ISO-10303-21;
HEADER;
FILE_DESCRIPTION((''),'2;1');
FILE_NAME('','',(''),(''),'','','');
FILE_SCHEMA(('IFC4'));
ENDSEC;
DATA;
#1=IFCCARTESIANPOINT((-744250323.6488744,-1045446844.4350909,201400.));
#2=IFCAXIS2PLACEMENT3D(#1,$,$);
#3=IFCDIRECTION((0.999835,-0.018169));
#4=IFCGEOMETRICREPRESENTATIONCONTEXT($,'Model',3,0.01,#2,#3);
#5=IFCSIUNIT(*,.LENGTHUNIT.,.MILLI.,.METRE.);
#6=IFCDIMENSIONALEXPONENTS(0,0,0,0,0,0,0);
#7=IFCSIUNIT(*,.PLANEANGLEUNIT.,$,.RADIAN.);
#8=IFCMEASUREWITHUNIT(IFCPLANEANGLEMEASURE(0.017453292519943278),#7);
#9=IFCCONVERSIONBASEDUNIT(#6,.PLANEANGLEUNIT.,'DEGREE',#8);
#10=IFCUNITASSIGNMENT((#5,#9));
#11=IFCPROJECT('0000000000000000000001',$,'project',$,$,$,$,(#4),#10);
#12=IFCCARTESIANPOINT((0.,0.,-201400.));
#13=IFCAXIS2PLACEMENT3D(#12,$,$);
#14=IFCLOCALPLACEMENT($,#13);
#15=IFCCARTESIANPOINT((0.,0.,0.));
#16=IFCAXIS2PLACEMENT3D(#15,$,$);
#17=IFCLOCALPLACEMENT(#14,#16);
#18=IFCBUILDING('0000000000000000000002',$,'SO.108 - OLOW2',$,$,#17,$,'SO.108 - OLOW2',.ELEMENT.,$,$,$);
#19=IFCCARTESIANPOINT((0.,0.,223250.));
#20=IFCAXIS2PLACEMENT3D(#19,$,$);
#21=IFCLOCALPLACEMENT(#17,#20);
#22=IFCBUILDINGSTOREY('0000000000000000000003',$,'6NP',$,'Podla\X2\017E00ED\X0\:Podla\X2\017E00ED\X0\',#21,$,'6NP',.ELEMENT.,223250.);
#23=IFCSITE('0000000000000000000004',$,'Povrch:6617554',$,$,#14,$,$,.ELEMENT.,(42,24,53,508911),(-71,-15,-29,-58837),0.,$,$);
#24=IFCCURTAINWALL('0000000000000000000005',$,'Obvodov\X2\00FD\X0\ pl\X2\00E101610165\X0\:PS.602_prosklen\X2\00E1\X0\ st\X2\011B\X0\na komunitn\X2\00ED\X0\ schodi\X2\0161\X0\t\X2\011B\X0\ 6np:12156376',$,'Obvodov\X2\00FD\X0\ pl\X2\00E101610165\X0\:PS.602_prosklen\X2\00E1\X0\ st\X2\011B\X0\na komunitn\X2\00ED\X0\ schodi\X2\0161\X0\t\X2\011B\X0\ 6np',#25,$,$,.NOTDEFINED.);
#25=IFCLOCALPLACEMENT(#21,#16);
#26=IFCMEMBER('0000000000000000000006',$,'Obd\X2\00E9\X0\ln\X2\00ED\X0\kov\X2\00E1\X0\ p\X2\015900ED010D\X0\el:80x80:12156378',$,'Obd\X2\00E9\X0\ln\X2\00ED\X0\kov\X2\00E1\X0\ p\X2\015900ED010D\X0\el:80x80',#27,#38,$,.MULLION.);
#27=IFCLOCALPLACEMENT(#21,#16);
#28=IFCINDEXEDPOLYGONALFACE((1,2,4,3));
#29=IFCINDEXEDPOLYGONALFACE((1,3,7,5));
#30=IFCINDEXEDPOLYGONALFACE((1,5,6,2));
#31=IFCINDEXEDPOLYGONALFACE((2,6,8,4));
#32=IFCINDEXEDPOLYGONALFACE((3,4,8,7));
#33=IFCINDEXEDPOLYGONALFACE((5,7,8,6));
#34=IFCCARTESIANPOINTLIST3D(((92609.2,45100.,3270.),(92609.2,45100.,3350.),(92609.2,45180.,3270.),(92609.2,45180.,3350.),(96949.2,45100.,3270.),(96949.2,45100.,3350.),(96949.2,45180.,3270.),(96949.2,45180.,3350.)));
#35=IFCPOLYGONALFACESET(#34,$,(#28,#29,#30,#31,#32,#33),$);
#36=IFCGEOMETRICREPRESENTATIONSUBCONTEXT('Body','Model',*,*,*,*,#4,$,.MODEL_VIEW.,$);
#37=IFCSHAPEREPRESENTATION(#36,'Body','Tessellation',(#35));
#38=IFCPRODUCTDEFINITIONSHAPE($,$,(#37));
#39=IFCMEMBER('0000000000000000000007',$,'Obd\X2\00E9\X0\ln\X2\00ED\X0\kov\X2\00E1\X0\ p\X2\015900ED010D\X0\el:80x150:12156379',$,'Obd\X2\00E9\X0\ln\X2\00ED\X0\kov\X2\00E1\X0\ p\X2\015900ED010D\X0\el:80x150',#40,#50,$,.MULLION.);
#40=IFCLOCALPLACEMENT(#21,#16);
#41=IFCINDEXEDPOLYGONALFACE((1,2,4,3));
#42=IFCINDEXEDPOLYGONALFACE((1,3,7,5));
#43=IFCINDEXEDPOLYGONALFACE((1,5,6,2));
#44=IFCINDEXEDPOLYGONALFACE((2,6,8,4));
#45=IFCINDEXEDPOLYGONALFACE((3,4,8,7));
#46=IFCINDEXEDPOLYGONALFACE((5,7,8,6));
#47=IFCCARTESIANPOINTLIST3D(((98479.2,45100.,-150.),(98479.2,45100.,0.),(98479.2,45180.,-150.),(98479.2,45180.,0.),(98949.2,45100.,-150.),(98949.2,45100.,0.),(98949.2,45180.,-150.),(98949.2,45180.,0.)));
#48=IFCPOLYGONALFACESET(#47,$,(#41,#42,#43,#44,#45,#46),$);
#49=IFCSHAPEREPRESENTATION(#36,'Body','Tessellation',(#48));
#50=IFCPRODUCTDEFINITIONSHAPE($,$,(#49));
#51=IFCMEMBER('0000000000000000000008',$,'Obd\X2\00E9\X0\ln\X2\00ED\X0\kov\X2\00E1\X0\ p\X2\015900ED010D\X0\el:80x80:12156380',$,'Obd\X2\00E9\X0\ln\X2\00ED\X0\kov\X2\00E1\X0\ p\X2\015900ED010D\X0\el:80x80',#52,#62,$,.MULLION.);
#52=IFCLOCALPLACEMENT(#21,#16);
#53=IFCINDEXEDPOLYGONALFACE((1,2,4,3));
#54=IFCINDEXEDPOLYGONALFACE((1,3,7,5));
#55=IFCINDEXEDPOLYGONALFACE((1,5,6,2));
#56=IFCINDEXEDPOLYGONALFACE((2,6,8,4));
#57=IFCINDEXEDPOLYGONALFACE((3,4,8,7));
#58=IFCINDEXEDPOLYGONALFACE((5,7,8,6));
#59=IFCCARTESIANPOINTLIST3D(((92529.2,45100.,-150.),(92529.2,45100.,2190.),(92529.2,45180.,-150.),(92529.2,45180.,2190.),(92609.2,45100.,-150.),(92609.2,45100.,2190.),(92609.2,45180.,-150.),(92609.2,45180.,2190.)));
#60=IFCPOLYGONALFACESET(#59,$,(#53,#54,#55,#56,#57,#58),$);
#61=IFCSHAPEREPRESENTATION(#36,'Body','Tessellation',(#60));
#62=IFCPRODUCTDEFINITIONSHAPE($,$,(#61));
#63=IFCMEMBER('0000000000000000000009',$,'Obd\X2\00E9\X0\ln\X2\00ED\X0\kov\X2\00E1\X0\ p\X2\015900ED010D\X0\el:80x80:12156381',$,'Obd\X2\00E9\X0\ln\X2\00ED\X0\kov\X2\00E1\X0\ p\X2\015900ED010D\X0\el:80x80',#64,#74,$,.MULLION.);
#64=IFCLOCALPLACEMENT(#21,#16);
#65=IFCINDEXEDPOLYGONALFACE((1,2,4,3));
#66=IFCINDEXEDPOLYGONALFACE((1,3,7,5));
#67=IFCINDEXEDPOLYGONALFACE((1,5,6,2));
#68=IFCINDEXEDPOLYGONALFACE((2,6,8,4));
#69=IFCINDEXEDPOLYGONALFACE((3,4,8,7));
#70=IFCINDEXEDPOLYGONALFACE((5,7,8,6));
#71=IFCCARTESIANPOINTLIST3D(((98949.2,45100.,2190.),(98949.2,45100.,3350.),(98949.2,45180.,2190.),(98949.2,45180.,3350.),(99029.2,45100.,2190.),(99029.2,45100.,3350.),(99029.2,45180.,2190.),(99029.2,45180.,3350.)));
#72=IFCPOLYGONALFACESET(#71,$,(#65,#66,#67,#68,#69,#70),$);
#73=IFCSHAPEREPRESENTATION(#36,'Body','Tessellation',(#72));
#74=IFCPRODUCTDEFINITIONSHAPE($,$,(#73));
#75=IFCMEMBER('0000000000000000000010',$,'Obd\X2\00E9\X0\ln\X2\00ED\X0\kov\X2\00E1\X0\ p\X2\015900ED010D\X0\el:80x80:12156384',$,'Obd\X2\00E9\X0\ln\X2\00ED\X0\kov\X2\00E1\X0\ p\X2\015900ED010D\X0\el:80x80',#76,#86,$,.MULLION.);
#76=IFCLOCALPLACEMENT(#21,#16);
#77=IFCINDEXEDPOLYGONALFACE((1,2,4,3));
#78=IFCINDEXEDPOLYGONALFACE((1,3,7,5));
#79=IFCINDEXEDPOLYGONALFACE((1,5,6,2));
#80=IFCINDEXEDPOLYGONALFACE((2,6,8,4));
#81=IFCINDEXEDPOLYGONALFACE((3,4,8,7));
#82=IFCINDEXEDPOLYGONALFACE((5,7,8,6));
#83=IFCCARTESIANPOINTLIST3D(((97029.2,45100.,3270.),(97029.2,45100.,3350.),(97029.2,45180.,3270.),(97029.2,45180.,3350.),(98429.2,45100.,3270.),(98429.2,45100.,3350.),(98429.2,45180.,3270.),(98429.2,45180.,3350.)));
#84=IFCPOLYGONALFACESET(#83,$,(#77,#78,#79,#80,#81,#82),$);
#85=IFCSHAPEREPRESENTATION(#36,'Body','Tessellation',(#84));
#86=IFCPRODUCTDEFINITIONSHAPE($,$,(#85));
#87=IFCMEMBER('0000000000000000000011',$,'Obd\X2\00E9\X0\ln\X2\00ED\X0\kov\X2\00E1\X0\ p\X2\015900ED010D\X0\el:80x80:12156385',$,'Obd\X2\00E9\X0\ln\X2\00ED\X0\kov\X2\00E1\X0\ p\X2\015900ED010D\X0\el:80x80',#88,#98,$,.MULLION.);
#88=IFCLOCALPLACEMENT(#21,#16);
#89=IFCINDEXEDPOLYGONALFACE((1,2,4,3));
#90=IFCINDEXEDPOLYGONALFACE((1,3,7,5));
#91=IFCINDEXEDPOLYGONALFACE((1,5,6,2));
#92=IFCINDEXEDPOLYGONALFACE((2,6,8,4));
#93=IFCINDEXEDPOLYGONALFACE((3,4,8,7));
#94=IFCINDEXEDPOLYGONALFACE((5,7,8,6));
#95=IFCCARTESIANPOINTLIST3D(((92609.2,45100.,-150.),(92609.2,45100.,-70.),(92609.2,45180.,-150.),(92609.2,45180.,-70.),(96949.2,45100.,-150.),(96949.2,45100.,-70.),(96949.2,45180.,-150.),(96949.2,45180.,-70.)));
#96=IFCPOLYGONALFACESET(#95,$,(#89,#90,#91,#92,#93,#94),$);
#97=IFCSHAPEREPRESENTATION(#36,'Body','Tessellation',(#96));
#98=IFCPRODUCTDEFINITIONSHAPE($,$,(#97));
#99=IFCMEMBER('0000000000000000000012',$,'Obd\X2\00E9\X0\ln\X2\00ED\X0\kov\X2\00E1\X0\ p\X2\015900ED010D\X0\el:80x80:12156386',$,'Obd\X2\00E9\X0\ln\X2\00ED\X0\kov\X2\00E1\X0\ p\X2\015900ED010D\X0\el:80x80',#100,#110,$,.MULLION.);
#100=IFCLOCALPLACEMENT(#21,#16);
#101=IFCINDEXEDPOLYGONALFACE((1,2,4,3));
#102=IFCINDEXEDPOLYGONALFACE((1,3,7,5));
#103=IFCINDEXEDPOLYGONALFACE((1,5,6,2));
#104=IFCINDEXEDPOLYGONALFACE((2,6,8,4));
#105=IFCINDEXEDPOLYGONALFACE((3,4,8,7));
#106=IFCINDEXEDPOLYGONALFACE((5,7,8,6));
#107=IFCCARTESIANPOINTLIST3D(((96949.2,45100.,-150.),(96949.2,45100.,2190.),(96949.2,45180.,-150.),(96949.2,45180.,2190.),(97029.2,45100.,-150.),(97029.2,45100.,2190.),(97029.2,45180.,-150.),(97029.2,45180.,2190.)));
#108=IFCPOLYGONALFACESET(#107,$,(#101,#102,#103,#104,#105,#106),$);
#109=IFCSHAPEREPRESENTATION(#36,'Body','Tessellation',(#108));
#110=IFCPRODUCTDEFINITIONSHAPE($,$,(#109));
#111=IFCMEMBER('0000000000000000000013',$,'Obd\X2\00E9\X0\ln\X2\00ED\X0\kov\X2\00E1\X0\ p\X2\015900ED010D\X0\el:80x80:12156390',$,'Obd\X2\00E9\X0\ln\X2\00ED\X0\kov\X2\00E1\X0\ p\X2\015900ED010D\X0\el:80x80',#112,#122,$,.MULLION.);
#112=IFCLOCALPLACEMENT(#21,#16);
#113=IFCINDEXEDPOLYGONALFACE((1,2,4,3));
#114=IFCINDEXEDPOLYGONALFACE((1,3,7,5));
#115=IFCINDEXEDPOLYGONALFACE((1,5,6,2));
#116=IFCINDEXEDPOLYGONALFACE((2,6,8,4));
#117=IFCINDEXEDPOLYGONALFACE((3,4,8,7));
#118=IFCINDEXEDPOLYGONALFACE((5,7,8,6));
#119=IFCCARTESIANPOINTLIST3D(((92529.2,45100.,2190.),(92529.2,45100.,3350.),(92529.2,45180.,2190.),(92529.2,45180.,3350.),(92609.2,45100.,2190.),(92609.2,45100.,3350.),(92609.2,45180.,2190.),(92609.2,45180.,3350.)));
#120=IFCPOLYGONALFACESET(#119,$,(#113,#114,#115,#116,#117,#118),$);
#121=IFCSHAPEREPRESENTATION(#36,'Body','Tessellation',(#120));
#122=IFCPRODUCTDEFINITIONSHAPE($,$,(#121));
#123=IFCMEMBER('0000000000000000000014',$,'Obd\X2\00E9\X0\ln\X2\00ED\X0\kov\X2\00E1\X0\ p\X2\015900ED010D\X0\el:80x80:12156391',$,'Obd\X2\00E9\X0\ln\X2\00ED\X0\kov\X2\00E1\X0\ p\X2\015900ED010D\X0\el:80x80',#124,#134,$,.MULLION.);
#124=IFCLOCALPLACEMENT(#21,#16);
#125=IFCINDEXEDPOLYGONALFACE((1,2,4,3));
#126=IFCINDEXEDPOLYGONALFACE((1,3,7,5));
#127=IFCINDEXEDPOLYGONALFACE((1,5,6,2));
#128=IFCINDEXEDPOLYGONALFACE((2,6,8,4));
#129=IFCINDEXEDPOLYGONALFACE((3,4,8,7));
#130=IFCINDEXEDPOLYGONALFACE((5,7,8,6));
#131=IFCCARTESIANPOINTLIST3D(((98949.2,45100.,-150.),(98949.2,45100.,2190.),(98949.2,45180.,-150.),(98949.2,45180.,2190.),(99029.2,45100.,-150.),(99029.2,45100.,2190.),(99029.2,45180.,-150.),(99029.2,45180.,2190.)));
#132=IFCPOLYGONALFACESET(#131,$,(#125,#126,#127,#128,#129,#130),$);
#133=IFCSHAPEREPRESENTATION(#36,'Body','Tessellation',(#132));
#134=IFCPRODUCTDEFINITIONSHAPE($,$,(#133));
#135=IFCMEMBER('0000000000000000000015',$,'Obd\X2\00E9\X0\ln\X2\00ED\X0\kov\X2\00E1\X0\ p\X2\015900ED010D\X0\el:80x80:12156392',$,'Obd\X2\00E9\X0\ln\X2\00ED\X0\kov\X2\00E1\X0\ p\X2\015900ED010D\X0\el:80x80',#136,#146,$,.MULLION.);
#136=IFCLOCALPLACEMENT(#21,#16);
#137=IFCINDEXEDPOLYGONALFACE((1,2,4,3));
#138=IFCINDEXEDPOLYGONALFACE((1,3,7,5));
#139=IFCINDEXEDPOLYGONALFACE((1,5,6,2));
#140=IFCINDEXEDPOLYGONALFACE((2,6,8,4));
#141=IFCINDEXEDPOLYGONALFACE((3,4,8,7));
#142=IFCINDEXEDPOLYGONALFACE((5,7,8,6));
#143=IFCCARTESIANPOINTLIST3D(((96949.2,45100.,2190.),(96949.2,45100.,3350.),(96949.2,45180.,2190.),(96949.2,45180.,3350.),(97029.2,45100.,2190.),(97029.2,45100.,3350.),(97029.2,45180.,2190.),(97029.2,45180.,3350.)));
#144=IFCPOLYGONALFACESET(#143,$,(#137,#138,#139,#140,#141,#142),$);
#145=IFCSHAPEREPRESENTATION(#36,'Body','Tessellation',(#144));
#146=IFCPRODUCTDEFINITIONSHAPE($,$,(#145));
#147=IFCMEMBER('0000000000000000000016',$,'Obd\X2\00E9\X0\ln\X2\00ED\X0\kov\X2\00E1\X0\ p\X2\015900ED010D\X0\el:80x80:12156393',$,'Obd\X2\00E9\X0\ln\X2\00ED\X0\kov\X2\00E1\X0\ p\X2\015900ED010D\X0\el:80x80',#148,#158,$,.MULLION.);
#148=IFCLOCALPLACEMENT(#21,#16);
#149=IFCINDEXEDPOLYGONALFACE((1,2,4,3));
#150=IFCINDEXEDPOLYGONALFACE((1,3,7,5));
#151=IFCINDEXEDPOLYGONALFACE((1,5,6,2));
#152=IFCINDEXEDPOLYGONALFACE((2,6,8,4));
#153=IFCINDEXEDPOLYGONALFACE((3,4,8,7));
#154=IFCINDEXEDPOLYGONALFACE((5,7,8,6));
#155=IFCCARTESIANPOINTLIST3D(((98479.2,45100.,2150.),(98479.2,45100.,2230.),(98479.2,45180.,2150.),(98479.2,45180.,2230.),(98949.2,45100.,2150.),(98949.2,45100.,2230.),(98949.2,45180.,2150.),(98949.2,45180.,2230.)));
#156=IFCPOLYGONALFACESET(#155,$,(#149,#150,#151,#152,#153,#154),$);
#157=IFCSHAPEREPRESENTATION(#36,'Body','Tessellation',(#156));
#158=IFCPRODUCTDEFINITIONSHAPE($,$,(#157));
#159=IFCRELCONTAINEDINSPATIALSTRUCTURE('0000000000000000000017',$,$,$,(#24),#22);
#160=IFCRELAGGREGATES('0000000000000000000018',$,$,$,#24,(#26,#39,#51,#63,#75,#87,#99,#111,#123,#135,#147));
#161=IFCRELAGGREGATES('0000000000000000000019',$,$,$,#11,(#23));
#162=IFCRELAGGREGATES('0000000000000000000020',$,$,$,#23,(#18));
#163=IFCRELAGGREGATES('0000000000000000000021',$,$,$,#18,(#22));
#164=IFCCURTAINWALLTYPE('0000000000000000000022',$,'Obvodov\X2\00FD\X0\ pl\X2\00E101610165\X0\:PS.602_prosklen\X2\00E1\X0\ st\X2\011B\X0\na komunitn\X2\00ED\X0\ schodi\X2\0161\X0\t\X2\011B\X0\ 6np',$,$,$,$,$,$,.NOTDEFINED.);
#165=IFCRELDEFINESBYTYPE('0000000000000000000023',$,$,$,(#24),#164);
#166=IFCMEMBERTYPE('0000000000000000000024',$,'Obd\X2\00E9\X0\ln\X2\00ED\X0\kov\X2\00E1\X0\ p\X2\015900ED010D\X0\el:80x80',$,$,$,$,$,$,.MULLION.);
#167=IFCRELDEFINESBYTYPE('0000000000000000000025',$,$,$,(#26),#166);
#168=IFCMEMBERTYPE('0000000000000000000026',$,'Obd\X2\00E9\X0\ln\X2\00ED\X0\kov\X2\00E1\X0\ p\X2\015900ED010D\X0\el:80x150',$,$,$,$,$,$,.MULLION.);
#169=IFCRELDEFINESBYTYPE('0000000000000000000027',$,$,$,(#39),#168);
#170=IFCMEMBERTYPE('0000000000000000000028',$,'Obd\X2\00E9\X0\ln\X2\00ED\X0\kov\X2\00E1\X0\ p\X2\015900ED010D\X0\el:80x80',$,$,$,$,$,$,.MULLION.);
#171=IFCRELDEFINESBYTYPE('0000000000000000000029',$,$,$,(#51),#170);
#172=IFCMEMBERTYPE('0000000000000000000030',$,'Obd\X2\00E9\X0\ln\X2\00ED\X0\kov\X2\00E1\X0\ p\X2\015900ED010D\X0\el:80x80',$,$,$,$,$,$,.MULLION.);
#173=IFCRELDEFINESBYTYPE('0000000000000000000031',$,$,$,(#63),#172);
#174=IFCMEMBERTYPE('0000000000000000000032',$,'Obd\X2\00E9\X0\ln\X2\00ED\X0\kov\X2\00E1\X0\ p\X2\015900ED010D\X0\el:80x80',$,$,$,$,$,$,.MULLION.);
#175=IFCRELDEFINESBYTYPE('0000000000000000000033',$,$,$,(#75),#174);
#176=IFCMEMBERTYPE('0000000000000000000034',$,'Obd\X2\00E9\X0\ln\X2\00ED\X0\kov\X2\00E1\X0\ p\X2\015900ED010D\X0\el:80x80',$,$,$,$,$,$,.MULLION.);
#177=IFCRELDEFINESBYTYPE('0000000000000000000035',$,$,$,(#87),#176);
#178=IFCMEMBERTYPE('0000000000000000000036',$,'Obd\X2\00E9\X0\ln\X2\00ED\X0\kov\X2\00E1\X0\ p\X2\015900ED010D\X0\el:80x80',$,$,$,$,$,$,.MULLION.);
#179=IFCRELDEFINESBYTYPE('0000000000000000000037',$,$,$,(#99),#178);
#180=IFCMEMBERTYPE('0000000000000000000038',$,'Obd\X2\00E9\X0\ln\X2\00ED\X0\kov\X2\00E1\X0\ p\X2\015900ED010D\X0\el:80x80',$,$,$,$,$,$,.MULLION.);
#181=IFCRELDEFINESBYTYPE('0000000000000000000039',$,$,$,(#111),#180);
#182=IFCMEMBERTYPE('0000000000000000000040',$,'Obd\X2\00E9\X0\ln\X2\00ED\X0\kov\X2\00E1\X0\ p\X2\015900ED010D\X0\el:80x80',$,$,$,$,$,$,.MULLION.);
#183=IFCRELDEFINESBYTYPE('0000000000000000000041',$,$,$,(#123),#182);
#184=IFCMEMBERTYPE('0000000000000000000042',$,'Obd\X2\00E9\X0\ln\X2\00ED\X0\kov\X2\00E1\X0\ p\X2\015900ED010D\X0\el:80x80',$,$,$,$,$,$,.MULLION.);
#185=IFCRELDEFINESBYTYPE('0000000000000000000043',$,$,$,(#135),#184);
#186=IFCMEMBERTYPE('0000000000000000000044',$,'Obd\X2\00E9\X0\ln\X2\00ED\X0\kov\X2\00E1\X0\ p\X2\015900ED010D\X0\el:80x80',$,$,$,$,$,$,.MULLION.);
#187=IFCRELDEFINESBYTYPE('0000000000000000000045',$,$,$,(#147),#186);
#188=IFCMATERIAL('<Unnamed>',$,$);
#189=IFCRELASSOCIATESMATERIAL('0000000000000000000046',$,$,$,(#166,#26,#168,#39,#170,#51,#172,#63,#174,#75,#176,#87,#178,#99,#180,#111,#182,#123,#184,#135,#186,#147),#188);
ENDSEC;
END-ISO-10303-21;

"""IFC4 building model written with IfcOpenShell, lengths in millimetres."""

from ifc_helpers import new_model, entity, si_unit, converted_unit, direction, frame, origin, place, context, subcontext, project, spatial, indexed_curve, outline, extrude, source, transform, mapped, material, type_object, type_shapes, element, aggregate, save


model = new_model("IFC4")

# Units and contexts
model_context = context("Model", 3, precision=0.01, world=frame((-744250323.6488744, -1045446844.4350909, 201400.0)), true_north=direction((0.999835, -0.018169)))
body_context = subcontext(model_context, "Body", "Model", "MODEL_VIEW")
ifc_project = project(units=[si_unit("LENGTHUNIT", "METRE", prefix="MILLI"), converted_unit("PLANEANGLEUNIT", "DEGREE", entity("IfcPlaneAngleMeasure", 0.017453292519943278), si_unit("PLANEANGLEUNIT", "RADIAN"), dimensions=[0, 0, 0, 0, 0, 0, 0])], contexts=[model_context])

# Site, building, storey
site_placement = place(None, frame((0.0, 0.0, -201400.0)))
site = spatial("IfcSite", under=ifc_project, at=site_placement, Name="Povrch:6617554", CompositionType="ELEMENT", RefLatitude=(42, 24, 53, 508911), RefLongitude=(-71, -15, -29, -58837), RefElevation=0.0)
building_placement = place(site_placement, origin())
building = spatial("IfcBuilding", under=site, at=building_placement, Name="SO.108 - OLOW2", LongName="SO.108 - OLOW2", CompositionType="ELEMENT")
storey_placement = place(building_placement, frame((0.0, 0.0, 223250.0)))
storey = spatial("IfcBuildingStorey", under=building, at=storey_placement, Name="6NP", ObjectType="Podlaží:Podlaží", LongName="6NP", CompositionType="ELEMENT", Elevation=223250.0)

# Curtain wall, members
curtain_wall_type_1 = type_object("IfcCurtainWallType", Name="Obvodový plášť:PS.602_prosklená stěna komunitní schodiště 6np", PredefinedType="NOTDEFINED")
curtain_wall_1_placement = place(storey_placement, frame((0.0, 0.0, -223250.0)))
curtain_wall_1 = element("IfcCurtainWall", 1, at=curtain_wall_1_placement, inside=storey, type_object=curtain_wall_type_1, Name="Obvodový plášť:PS.602_prosklená stěna komunitní schodiště 6np:12156376", ObjectType="Obvodový plášť:PS.602_prosklená stěna komunitní schodiště 6np", PredefinedType="NOTDEFINED")
ifc_material_1 = material(Name="<Unnamed>")
member_type_1 = type_object("IfcMemberType", Name="Obdélníková příčel:80x80", PredefinedType="MULLION", material=ifc_material_1)
shared_shape_1 = source(origin(), body_context, "Body", "SweptSolid", [
    extrude(outline(indexed_curve([(-40.0, -40.0), (40.0, -40.0), (40.0, 40.0), (-40.0, 40.0), (-40.0, -40.0)], self_intersect=False)), frame((-40.0, 0.0, -4340.0), z_axis=(0.0, 0.0, 1.0), x_axis=(-1.0, 0.0, 0.0)), (0.0, 0.0, 1.0), 4340.0),
])
type_shapes(member_type_1, [shared_shape_1])
member_1_placement = place(curtain_wall_1_placement, frame((92609.2, 45140.0, 226600.0), z_axis=(-1.0, 0.0, 0.0), x_axis=(0.0, 0.0, 1.0)))
member_1 = element("IfcMember", 2, at=member_1_placement, type_object=member_type_1, material=ifc_material_1, Name="Obdélníková příčel:80x80:12156378", ObjectType="Obdélníková příčel:80x80", PredefinedType="MULLION", context=body_context, shape_type="MappedRepresentation", body=[
    mapped(shared_shape_1, transform((0.0, 0.0, 0.0), scale=1.0)),
])
member_type_2 = type_object("IfcMemberType", Name="Obdélníková příčel:80x150", PredefinedType="MULLION", material=ifc_material_1)
shared_shape_2 = source(origin(), body_context, "Body", "SweptSolid", [
    extrude(outline(indexed_curve([(-75.0, -40.0), (75.0, -40.0), (75.0, 40.0), (-75.0, 40.0), (-75.0, -40.0)], self_intersect=False)), frame((-75.0, 0.0, -470.0), z_axis=(0.0, 0.0, 1.0), x_axis=(-1.0, 0.0, 0.0)), (0.0, 0.0, 1.0), 470.0),
])
type_shapes(member_type_2, [shared_shape_2])
member_2_placement = place(curtain_wall_1_placement, frame((98949.2, 45140.0, 223100.0), z_axis=(1.0, 0.0, 0.0), x_axis=(0.0, 0.0, -1.0)))
member_2 = element("IfcMember", 3, at=member_2_placement, type_object=member_type_2, material=ifc_material_1, Name="Obdélníková příčel:80x150:12156379", ObjectType="Obdélníková příčel:80x150", PredefinedType="MULLION", context=body_context, shape_type="MappedRepresentation", body=[
    mapped(shared_shape_2, transform((0.0, 0.0, 0.0), scale=1.0)),
])
member_type_3 = type_object("IfcMemberType", Name="Obdélníková příčel:80x80", PredefinedType="MULLION", material=ifc_material_1)
shared_shape_3 = source(origin(), body_context, "Body", "SweptSolid", [
    extrude(outline(indexed_curve([(-40.0, -40.0), (40.0, -40.0), (40.0, 40.0), (-40.0, 40.0), (-40.0, -40.0)], self_intersect=False)), frame((-40.0, 0.0, -2340.0), z_axis=(0.0, 0.0, 1.0), x_axis=(-1.0, 0.0, 0.0)), (0.0, 0.0, 1.0), 2340.0),
])
type_shapes(member_type_3, [shared_shape_3])
member_3_placement = place(curtain_wall_1_placement, frame((92529.2, 45140.0, 223100.0), z_axis=(0.0, 0.0, -1.0), x_axis=(-1.0, 0.0, 0.0)))
member_3 = element("IfcMember", 4, at=member_3_placement, type_object=member_type_3, material=ifc_material_1, Name="Obdélníková příčel:80x80:12156380", ObjectType="Obdélníková příčel:80x80", PredefinedType="MULLION", context=body_context, shape_type="MappedRepresentation", body=[
    mapped(shared_shape_3, transform((0.0, 0.0, 0.0), scale=1.0)),
])
member_type_4 = type_object("IfcMemberType", Name="Obdélníková příčel:80x80", PredefinedType="MULLION", material=ifc_material_1)
shared_shape_4 = source(origin(), body_context, "Body", "SweptSolid", [
    extrude(outline(indexed_curve([(-40.0, -40.0), (40.0, -40.0), (40.0, 40.0), (-40.0, 40.0), (-40.0, -40.0)], self_intersect=False)), frame((-40.0, 0.0, -1160.0), z_axis=(0.0, 0.0, 1.0), x_axis=(-1.0, 0.0, 0.0)), (0.0, 0.0, 1.0), 1160.0),
])
type_shapes(member_type_4, [shared_shape_4])
member_4_placement = place(curtain_wall_1_placement, frame((99029.2, 45140.0, 226600.0)))
member_4 = element("IfcMember", 5, at=member_4_placement, type_object=member_type_4, material=ifc_material_1, Name="Obdélníková příčel:80x80:12156381", ObjectType="Obdélníková příčel:80x80", PredefinedType="MULLION", context=body_context, shape_type="MappedRepresentation", body=[
    mapped(shared_shape_4, transform((0.0, 0.0, 0.0), scale=1.0)),
])
member_type_5 = type_object("IfcMemberType", Name="Obdélníková příčel:80x80", PredefinedType="MULLION", material=ifc_material_1)
shared_shape_5 = source(origin(), body_context, "Body", "SweptSolid", [
    extrude(outline(indexed_curve([(-40.0, -40.0), (40.0, -40.0), (40.0, 40.0), (-40.0, 40.0), (-40.0, -40.0)], self_intersect=False)), frame((-40.0, 0.0, -1400.0), z_axis=(0.0, 0.0, 1.0), x_axis=(-1.0, 0.0, 0.0)), (0.0, 0.0, 1.0), 1400.0),
])
type_shapes(member_type_5, [shared_shape_5])
member_5_placement = place(curtain_wall_1_placement, frame((97029.2, 45140.0, 226600.0), z_axis=(-1.0, 0.0, 0.0), x_axis=(0.0, 0.0, 1.0)))
member_5 = element("IfcMember", 6, at=member_5_placement, type_object=member_type_5, material=ifc_material_1, Name="Obdélníková příčel:80x80:12156384", ObjectType="Obdélníková příčel:80x80", PredefinedType="MULLION", context=body_context, shape_type="MappedRepresentation", body=[
    mapped(shared_shape_5, transform((0.0, 0.0, 0.0), scale=1.0)),
])
member_type_6 = type_object("IfcMemberType", Name="Obdélníková příčel:80x80", PredefinedType="MULLION", material=ifc_material_1)
shared_shape_6 = source(origin(), body_context, "Body", "SweptSolid", [
    extrude(outline(indexed_curve([(-40.0, -40.0), (40.0, -40.0), (40.0, 40.0), (-40.0, 40.0), (-40.0, -40.0)], self_intersect=False)), frame((-40.0, 0.0, -4340.0), z_axis=(0.0, 0.0, 1.0), x_axis=(-1.0, 0.0, 0.0)), (0.0, 0.0, 1.0), 4340.0),
])
type_shapes(member_type_6, [shared_shape_6])
member_6_placement = place(curtain_wall_1_placement, frame((96949.2, 45140.0, 223100.0), z_axis=(1.0, 0.0, 0.0), x_axis=(0.0, 0.0, -1.0)))
member_6 = element("IfcMember", 7, at=member_6_placement, type_object=member_type_6, material=ifc_material_1, Name="Obdélníková příčel:80x80:12156385", ObjectType="Obdélníková příčel:80x80", PredefinedType="MULLION", context=body_context, shape_type="MappedRepresentation", body=[
    mapped(shared_shape_6, transform((0.0, 0.0, 0.0), scale=1.0)),
])
member_type_7 = type_object("IfcMemberType", Name="Obdélníková příčel:80x80", PredefinedType="MULLION", material=ifc_material_1)
shared_shape_7 = source(origin(), body_context, "Body", "SweptSolid", [
    extrude(outline(indexed_curve([(-40.0, -40.0), (40.0, -40.0), (40.0, 40.0), (-40.0, 40.0), (-40.0, -40.0)], self_intersect=False)), frame((0.0, 0.0, -2340.0), z_axis=(0.0, 0.0, 1.0), x_axis=(-1.0, 0.0, 0.0)), (0.0, 0.0, 1.0), 2340.0),
])
type_shapes(member_type_7, [shared_shape_7])
member_7_placement = place(curtain_wall_1_placement, frame((96989.2, 45140.0, 223100.0), z_axis=(0.0, 0.0, -1.0), x_axis=(-1.0, 0.0, 0.0)))
member_7 = element("IfcMember", 8, at=member_7_placement, type_object=member_type_7, material=ifc_material_1, Name="Obdélníková příčel:80x80:12156386", ObjectType="Obdélníková příčel:80x80", PredefinedType="MULLION", context=body_context, shape_type="MappedRepresentation", body=[
    mapped(shared_shape_7, transform((0.0, 0.0, 0.0), scale=1.0)),
])
member_type_8 = type_object("IfcMemberType", Name="Obdélníková příčel:80x80", PredefinedType="MULLION", material=ifc_material_1)
shared_shape_8 = source(origin(), body_context, "Body", "SweptSolid", [
    extrude(outline(indexed_curve([(-40.0, -40.0), (40.0, -40.0), (40.0, 40.0), (-40.0, 40.0), (-40.0, -40.0)], self_intersect=False)), frame((-40.0, 0.0, -1160.0), z_axis=(0.0, 0.0, 1.0), x_axis=(-1.0, 0.0, 0.0)), (0.0, 0.0, 1.0), 1160.0),
])
type_shapes(member_type_8, [shared_shape_8])
member_8_placement = place(curtain_wall_1_placement, frame((92529.2, 45140.0, 225440.0), z_axis=(0.0, 0.0, -1.0), x_axis=(-1.0, 0.0, 0.0)))
member_8 = element("IfcMember", 9, at=member_8_placement, type_object=member_type_8, material=ifc_material_1, Name="Obdélníková příčel:80x80:12156390", ObjectType="Obdélníková příčel:80x80", PredefinedType="MULLION", context=body_context, shape_type="MappedRepresentation", body=[
    mapped(shared_shape_8, transform((0.0, 0.0, 0.0), scale=1.0)),
])
member_type_9 = type_object("IfcMemberType", Name="Obdélníková příčel:80x80", PredefinedType="MULLION", material=ifc_material_1)
shared_shape_9 = source(origin(), body_context, "Body", "SweptSolid", [
    extrude(outline(indexed_curve([(-40.0, -40.0), (40.0, -40.0), (40.0, 40.0), (-40.0, 40.0), (-40.0, -40.0)], self_intersect=False)), frame((-40.0, 0.0, -2340.0), z_axis=(0.0, 0.0, 1.0), x_axis=(-1.0, 0.0, 0.0)), (0.0, 0.0, 1.0), 2340.0),
])
type_shapes(member_type_9, [shared_shape_9])
member_9_placement = place(curtain_wall_1_placement, frame((99029.2, 45140.0, 225440.0)))
member_9 = element("IfcMember", 10, at=member_9_placement, type_object=member_type_9, material=ifc_material_1, Name="Obdélníková příčel:80x80:12156391", ObjectType="Obdélníková příčel:80x80", PredefinedType="MULLION", context=body_context, shape_type="MappedRepresentation", body=[
    mapped(shared_shape_9, transform((0.0, 0.0, 0.0), scale=1.0)),
])
member_type_10 = type_object("IfcMemberType", Name="Obdélníková příčel:80x80", PredefinedType="MULLION", material=ifc_material_1)
shared_shape_10 = source(origin(), body_context, "Body", "SweptSolid", [
    extrude(outline(indexed_curve([(-40.0, -40.0), (40.0, -40.0), (40.0, 40.0), (-40.0, 40.0), (-40.0, -40.0)], self_intersect=False)), frame((0.0, 0.0, -1160.0), z_axis=(0.0, 0.0, 1.0), x_axis=(-1.0, 0.0, 0.0)), (0.0, 0.0, 1.0), 1160.0),
])
type_shapes(member_type_10, [shared_shape_10])
member_10_placement = place(curtain_wall_1_placement, frame((96989.2, 45140.0, 225440.0), z_axis=(0.0, 0.0, -1.0), x_axis=(-1.0, 0.0, 0.0)))
member_10 = element("IfcMember", 11, at=member_10_placement, type_object=member_type_10, material=ifc_material_1, Name="Obdélníková příčel:80x80:12156392", ObjectType="Obdélníková příčel:80x80", PredefinedType="MULLION", context=body_context, shape_type="MappedRepresentation", body=[
    mapped(shared_shape_10, transform((0.0, 0.0, 0.0), scale=1.0)),
])
member_type_11 = type_object("IfcMemberType", Name="Obdélníková příčel:80x80", PredefinedType="MULLION", material=ifc_material_1)
shared_shape_11 = source(origin(), body_context, "Body", "SweptSolid", [
    extrude(outline(indexed_curve([(-40.0, -40.0), (40.0, -40.0), (40.0, 40.0), (-40.0, 40.0), (-40.0, -40.0)], self_intersect=False)), frame((0.0, 0.0, -470.0), z_axis=(0.0, 0.0, 1.0), x_axis=(-1.0, 0.0, 0.0)), (0.0, 0.0, 1.0), 470.0),
])
type_shapes(member_type_11, [shared_shape_11])
member_11_placement = place(curtain_wall_1_placement, frame((98479.2, 45140.0, 225440.0), z_axis=(-1.0, 0.0, 0.0), x_axis=(0.0, 0.0, 1.0)))
member_11 = element("IfcMember", 12, at=member_11_placement, type_object=member_type_11, material=ifc_material_1, Name="Obdélníková příčel:80x80:12156393", ObjectType="Obdélníková příčel:80x80", PredefinedType="MULLION", context=body_context, shape_type="MappedRepresentation", body=[
    mapped(shared_shape_11, transform((0.0, 0.0, 0.0), scale=1.0)),
])

aggregate(curtain_wall_1, [member_1, member_2, member_3, member_4, member_5, member_6, member_7, member_8, member_9, member_10, member_11])

save(model, "model.ifc")
